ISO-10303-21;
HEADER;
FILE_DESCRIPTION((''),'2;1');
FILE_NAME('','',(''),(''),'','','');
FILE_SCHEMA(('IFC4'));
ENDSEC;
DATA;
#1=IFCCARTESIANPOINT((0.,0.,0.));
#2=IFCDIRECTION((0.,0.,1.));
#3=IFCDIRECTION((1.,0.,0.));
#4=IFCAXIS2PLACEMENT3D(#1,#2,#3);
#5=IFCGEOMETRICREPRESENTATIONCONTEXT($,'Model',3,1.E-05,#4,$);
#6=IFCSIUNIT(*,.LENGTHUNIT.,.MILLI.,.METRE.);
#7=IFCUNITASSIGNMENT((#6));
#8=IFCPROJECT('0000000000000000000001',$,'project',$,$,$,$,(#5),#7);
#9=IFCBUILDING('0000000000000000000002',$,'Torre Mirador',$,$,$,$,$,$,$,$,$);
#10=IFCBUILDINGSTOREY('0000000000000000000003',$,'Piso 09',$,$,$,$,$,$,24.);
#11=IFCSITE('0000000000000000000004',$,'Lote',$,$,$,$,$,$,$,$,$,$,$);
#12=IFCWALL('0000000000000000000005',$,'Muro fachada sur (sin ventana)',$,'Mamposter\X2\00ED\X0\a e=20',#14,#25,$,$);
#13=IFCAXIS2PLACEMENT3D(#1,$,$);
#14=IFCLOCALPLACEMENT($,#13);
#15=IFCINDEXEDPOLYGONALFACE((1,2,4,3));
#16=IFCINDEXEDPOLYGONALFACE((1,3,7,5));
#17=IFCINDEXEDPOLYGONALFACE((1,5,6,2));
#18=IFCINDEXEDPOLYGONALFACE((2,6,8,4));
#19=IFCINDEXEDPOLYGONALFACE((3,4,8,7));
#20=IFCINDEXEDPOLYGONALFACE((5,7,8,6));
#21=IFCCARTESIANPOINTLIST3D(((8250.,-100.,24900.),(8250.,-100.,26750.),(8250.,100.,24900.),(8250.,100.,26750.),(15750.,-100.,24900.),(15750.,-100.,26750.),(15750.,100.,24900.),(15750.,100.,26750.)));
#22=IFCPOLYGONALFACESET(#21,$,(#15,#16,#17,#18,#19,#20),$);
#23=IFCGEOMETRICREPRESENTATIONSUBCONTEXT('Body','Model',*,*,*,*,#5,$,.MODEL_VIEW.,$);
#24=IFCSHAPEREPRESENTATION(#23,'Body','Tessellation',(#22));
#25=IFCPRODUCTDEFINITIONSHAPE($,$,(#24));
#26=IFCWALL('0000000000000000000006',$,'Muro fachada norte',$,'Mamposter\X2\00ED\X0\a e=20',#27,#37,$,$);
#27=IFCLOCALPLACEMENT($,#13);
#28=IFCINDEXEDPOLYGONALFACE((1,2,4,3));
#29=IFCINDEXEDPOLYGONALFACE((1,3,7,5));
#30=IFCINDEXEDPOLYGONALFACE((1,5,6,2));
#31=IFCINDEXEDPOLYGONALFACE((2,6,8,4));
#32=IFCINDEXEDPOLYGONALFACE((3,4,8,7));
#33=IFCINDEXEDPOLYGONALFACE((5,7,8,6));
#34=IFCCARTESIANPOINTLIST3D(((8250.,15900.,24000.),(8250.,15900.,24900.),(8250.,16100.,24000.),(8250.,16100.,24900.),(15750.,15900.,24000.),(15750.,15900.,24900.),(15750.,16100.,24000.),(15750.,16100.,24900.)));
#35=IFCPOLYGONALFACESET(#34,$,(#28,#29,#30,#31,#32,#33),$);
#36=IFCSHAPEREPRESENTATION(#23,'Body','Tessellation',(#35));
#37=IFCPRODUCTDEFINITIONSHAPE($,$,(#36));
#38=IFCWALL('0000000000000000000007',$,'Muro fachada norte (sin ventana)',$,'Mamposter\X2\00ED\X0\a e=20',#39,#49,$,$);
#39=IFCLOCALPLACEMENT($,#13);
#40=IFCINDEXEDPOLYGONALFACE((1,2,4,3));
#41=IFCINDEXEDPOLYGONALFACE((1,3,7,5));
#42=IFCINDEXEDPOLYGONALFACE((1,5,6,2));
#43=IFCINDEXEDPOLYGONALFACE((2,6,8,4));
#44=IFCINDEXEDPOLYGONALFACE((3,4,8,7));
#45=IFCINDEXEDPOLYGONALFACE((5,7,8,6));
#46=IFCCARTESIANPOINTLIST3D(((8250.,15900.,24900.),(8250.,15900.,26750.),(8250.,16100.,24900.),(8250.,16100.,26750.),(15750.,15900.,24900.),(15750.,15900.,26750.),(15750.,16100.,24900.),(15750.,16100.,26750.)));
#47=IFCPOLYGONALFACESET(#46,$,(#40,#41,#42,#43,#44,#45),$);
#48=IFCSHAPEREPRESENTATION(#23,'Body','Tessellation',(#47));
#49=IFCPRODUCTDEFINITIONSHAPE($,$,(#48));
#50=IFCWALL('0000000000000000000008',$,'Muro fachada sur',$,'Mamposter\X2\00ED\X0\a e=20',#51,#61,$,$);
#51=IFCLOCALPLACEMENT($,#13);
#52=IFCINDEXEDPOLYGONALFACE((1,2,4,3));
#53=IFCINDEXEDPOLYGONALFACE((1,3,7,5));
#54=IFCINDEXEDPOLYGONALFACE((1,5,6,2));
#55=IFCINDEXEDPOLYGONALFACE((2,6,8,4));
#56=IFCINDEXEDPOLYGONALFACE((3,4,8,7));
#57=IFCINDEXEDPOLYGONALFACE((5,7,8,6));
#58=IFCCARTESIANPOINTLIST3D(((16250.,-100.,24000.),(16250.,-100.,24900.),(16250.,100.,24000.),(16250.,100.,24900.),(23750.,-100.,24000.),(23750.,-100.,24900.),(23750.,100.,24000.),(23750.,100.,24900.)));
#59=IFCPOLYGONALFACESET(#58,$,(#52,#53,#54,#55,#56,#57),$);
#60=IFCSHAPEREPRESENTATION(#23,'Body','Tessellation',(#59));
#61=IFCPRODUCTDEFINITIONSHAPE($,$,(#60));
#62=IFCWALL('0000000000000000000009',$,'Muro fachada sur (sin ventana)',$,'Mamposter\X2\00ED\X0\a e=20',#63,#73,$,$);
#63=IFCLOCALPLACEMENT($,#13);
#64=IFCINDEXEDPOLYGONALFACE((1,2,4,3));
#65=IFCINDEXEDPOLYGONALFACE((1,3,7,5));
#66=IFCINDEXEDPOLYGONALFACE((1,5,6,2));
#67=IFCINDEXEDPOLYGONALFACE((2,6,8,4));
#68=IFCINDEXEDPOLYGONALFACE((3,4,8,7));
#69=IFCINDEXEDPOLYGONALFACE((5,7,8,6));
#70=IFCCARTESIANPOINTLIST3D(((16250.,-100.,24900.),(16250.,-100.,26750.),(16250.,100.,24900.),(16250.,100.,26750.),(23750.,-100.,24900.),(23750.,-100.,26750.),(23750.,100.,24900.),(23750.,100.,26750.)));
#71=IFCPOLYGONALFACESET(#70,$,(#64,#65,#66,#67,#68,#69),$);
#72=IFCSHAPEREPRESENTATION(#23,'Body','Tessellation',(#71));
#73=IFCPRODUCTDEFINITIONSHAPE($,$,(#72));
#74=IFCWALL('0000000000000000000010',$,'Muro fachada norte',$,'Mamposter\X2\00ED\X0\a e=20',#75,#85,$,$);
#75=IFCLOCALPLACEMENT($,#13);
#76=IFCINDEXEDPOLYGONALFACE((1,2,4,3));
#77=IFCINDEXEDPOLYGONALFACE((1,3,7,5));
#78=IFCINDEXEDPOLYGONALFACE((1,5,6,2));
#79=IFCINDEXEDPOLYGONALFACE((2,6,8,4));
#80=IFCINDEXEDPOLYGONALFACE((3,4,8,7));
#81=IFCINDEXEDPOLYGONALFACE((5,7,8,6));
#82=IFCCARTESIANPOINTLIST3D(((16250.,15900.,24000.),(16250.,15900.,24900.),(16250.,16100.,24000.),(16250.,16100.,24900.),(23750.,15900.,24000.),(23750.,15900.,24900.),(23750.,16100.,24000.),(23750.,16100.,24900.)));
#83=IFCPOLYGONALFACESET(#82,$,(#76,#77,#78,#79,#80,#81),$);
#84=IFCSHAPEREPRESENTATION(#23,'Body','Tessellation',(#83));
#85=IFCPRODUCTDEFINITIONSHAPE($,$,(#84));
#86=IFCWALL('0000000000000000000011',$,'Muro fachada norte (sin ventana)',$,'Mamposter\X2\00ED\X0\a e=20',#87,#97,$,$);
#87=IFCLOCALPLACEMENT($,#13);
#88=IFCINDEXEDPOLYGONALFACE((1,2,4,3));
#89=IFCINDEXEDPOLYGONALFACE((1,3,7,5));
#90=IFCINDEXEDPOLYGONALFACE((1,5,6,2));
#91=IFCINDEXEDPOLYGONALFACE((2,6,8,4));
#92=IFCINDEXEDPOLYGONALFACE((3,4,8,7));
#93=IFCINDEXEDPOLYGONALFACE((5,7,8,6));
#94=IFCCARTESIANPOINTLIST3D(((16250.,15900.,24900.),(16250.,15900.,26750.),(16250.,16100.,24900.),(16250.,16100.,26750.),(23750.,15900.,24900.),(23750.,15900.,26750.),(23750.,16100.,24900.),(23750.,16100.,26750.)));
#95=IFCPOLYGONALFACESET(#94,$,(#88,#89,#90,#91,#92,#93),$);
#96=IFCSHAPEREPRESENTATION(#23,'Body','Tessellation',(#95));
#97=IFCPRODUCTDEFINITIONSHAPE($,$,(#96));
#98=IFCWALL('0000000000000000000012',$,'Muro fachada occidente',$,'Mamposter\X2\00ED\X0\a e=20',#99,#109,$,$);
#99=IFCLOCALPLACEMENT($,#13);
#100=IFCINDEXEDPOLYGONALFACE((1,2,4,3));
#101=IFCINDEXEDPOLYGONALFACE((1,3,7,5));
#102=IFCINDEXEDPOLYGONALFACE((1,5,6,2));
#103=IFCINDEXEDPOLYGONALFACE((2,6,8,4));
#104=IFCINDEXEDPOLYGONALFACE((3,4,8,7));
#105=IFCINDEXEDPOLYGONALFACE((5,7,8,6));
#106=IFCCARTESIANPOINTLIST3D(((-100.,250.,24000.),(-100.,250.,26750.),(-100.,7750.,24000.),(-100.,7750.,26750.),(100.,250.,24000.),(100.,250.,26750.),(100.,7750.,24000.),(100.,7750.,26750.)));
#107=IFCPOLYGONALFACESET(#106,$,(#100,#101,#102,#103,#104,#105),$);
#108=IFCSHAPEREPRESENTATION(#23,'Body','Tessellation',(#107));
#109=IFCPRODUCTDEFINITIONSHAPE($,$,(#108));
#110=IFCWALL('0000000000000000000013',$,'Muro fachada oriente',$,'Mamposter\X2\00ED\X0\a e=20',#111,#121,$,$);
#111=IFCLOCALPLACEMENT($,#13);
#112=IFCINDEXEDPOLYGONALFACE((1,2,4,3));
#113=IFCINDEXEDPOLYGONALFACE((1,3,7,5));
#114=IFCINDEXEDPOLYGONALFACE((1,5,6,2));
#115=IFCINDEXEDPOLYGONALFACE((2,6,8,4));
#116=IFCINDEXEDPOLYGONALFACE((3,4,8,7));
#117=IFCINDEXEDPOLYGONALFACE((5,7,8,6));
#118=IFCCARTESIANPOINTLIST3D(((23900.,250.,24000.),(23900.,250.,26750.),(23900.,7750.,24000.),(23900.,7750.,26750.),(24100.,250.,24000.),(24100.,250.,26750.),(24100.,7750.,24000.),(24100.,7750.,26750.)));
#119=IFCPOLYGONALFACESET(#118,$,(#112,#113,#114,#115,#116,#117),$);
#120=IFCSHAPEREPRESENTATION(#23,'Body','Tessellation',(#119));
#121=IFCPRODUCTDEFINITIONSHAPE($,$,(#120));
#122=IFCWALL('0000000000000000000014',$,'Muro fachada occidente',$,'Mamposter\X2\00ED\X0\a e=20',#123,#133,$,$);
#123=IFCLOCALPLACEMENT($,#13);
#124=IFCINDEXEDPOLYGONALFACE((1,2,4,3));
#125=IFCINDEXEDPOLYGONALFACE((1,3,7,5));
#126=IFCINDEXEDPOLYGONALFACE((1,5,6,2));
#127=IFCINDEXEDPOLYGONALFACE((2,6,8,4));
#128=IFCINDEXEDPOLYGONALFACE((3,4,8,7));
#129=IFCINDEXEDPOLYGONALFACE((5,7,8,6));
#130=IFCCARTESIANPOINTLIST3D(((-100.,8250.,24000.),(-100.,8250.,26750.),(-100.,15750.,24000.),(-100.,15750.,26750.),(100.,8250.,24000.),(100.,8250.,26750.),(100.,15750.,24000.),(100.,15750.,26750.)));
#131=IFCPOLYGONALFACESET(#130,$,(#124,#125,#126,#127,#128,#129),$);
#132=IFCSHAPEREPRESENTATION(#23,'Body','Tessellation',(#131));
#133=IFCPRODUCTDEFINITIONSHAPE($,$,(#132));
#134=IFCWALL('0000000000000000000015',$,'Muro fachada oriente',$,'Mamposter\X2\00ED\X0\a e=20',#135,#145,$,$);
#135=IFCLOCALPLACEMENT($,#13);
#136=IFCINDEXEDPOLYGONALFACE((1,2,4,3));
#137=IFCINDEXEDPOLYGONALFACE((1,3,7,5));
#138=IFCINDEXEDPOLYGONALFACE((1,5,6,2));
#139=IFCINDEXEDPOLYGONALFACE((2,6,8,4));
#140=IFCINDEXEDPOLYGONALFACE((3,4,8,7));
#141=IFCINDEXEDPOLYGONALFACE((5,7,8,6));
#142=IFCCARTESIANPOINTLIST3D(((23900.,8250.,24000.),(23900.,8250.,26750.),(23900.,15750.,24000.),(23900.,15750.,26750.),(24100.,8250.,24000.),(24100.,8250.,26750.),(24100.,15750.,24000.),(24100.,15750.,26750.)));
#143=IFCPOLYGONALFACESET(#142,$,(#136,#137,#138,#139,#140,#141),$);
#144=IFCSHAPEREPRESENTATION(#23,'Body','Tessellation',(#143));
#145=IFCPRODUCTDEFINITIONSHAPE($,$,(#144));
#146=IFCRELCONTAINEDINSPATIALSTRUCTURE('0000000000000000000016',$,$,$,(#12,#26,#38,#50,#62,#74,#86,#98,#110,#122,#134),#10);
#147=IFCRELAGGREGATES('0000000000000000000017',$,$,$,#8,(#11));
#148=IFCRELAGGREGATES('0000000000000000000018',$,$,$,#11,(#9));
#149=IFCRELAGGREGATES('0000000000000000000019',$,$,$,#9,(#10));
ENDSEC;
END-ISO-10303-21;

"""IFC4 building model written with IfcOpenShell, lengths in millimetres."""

from ifc_helpers import new_model, si_unit, frame, origin_with_axes, place, context, subcontext, project, spatial, indexed_curve, outline, extrude, element, save


model = new_model("IFC4")

# Units and contexts
model_context = context("Model", 3, precision=1e-05, world=origin_with_axes())
body_context = subcontext(model_context, "Body", "Model", "MODEL_VIEW")
ifc_project = project(units=[si_unit("LENGTHUNIT", "METRE", prefix="MILLI")], contexts=[model_context])

# Site, building, storey
site = spatial("IfcSite", under=ifc_project, Name="Lote")
building = spatial("IfcBuilding", under=site, Name="Torre Mirador")
storey = spatial("IfcBuildingStorey", under=building, Name="Piso 09", Elevation=24.0)

# Walls
wall_1_placement = place(None, frame((8250.0, -100.0, 24900.0), z_axis=(0.0, 0.0, 1.0), x_axis=(1.0, 0.0, 0.0)))
element("IfcWall", 1, at=wall_1_placement, inside=storey, Name="Muro fachada sur (sin ventana)", ObjectType="Mampostería e=20", context=body_context, shape_type="SweptSolid", body=[
    extrude(outline(indexed_curve([(0.0, 0.0), (0.0, 200.0), (7500.0, 200.0), (7500.0, 0.0), (0.0, 0.0)], self_intersect=False)), origin_with_axes(), (0.0, 0.0, 1.0), 1850.0),
])
wall_2_placement = place(None, frame((8250.0, 15900.0, 24000.0), z_axis=(0.0, 0.0, 1.0), x_axis=(1.0, 0.0, 0.0)))
element("IfcWall", 2, at=wall_2_placement, inside=storey, Name="Muro fachada norte", ObjectType="Mampostería e=20", context=body_context, shape_type="SweptSolid", body=[
    extrude(outline(indexed_curve([(0.0, 0.0), (0.0, 200.0), (7500.0, 200.0), (7500.0, 0.0), (0.0, 0.0)], self_intersect=False)), origin_with_axes(), (0.0, 0.0, 1.0), 900.0),
])
wall_3_placement = place(None, frame((8250.0, 15900.0, 24900.0), z_axis=(0.0, 0.0, 1.0), x_axis=(1.0, 0.0, 0.0)))
element("IfcWall", 3, at=wall_3_placement, inside=storey, Name="Muro fachada norte (sin ventana)", ObjectType="Mampostería e=20", context=body_context, shape_type="SweptSolid", body=[
    extrude(outline(indexed_curve([(0.0, 0.0), (0.0, 200.0), (7500.0, 200.0), (7500.0, 0.0), (0.0, 0.0)], self_intersect=False)), origin_with_axes(), (0.0, 0.0, 1.0), 1850.0),
])
wall_4_placement = place(None, frame((16250.0, -100.0, 24000.0), z_axis=(0.0, 0.0, 1.0), x_axis=(1.0, 0.0, 0.0)))
element("IfcWall", 4, at=wall_4_placement, inside=storey, Name="Muro fachada sur", ObjectType="Mampostería e=20", context=body_context, shape_type="SweptSolid", body=[
    extrude(outline(indexed_curve([(0.0, 0.0), (0.0, 200.0), (7500.0, 200.0), (7500.0, 0.0), (0.0, 0.0)], self_intersect=False)), origin_with_axes(), (0.0, 0.0, 1.0), 900.0),
])
wall_5_placement = place(None, frame((16250.0, -100.0, 24900.0), z_axis=(0.0, 0.0, 1.0), x_axis=(1.0, 0.0, 0.0)))
element("IfcWall", 5, at=wall_5_placement, inside=storey, Name="Muro fachada sur (sin ventana)", ObjectType="Mampostería e=20", context=body_context, shape_type="SweptSolid", body=[
    extrude(outline(indexed_curve([(0.0, 0.0), (0.0, 200.0), (7500.0, 200.0), (7500.0, 0.0), (0.0, 0.0)], self_intersect=False)), origin_with_axes(), (0.0, 0.0, 1.0), 1850.0),
])
wall_6_placement = place(None, frame((16250.0, 15900.0, 24000.0), z_axis=(0.0, 0.0, 1.0), x_axis=(1.0, 0.0, 0.0)))
element("IfcWall", 6, at=wall_6_placement, inside=storey, Name="Muro fachada norte", ObjectType="Mampostería e=20", context=body_context, shape_type="SweptSolid", body=[
    extrude(outline(indexed_curve([(0.0, 0.0), (0.0, 200.0), (7500.0, 200.0), (7500.0, 0.0), (0.0, 0.0)], self_intersect=False)), origin_with_axes(), (0.0, 0.0, 1.0), 900.0),
])
wall_7_placement = place(None, frame((16250.0, 15900.0, 24900.0), z_axis=(0.0, 0.0, 1.0), x_axis=(1.0, 0.0, 0.0)))
element("IfcWall", 7, at=wall_7_placement, inside=storey, Name="Muro fachada norte (sin ventana)", ObjectType="Mampostería e=20", context=body_context, shape_type="SweptSolid", body=[
    extrude(outline(indexed_curve([(0.0, 0.0), (0.0, 200.0), (7500.0, 200.0), (7500.0, 0.0), (0.0, 0.0)], self_intersect=False)), origin_with_axes(), (0.0, 0.0, 1.0), 1850.0),
])
for number, where, z_axis, x_axis, name in (
    (8, (-100.0, 250.0, 24000.0), (0.0, 0.0, 1.0), (1.0, 0.0, 0.0), "Muro fachada occidente"),
    (9, (23900.0, 250.0, 24000.0), (0.0, 0.0, 1.0), (1.0, 0.0, 0.0), "Muro fachada oriente"),
    (10, (-100.0, 8250.0, 24000.0), (0.0, 0.0, 1.0), (1.0, 0.0, 0.0), "Muro fachada occidente"),
    (11, (23900.0, 8250.0, 24000.0), (0.0, 0.0, 1.0), (1.0, 0.0, 0.0), "Muro fachada oriente"),
):
    element("IfcWall", number, at=place(None, frame(where, z_axis=z_axis, x_axis=x_axis)), inside=storey, Name=name, ObjectType="Mampostería e=20", context=body_context, shape_type="SweptSolid", body=[
        extrude(outline(indexed_curve([(0.0, 0.0), (0.0, 7500.0), (200.0, 7500.0), (200.0, 0.0), (0.0, 0.0)], self_intersect=False)), origin_with_axes(), (0.0, 0.0, 1.0), 2750.0),
    ])

save(model, "model.ifc")
